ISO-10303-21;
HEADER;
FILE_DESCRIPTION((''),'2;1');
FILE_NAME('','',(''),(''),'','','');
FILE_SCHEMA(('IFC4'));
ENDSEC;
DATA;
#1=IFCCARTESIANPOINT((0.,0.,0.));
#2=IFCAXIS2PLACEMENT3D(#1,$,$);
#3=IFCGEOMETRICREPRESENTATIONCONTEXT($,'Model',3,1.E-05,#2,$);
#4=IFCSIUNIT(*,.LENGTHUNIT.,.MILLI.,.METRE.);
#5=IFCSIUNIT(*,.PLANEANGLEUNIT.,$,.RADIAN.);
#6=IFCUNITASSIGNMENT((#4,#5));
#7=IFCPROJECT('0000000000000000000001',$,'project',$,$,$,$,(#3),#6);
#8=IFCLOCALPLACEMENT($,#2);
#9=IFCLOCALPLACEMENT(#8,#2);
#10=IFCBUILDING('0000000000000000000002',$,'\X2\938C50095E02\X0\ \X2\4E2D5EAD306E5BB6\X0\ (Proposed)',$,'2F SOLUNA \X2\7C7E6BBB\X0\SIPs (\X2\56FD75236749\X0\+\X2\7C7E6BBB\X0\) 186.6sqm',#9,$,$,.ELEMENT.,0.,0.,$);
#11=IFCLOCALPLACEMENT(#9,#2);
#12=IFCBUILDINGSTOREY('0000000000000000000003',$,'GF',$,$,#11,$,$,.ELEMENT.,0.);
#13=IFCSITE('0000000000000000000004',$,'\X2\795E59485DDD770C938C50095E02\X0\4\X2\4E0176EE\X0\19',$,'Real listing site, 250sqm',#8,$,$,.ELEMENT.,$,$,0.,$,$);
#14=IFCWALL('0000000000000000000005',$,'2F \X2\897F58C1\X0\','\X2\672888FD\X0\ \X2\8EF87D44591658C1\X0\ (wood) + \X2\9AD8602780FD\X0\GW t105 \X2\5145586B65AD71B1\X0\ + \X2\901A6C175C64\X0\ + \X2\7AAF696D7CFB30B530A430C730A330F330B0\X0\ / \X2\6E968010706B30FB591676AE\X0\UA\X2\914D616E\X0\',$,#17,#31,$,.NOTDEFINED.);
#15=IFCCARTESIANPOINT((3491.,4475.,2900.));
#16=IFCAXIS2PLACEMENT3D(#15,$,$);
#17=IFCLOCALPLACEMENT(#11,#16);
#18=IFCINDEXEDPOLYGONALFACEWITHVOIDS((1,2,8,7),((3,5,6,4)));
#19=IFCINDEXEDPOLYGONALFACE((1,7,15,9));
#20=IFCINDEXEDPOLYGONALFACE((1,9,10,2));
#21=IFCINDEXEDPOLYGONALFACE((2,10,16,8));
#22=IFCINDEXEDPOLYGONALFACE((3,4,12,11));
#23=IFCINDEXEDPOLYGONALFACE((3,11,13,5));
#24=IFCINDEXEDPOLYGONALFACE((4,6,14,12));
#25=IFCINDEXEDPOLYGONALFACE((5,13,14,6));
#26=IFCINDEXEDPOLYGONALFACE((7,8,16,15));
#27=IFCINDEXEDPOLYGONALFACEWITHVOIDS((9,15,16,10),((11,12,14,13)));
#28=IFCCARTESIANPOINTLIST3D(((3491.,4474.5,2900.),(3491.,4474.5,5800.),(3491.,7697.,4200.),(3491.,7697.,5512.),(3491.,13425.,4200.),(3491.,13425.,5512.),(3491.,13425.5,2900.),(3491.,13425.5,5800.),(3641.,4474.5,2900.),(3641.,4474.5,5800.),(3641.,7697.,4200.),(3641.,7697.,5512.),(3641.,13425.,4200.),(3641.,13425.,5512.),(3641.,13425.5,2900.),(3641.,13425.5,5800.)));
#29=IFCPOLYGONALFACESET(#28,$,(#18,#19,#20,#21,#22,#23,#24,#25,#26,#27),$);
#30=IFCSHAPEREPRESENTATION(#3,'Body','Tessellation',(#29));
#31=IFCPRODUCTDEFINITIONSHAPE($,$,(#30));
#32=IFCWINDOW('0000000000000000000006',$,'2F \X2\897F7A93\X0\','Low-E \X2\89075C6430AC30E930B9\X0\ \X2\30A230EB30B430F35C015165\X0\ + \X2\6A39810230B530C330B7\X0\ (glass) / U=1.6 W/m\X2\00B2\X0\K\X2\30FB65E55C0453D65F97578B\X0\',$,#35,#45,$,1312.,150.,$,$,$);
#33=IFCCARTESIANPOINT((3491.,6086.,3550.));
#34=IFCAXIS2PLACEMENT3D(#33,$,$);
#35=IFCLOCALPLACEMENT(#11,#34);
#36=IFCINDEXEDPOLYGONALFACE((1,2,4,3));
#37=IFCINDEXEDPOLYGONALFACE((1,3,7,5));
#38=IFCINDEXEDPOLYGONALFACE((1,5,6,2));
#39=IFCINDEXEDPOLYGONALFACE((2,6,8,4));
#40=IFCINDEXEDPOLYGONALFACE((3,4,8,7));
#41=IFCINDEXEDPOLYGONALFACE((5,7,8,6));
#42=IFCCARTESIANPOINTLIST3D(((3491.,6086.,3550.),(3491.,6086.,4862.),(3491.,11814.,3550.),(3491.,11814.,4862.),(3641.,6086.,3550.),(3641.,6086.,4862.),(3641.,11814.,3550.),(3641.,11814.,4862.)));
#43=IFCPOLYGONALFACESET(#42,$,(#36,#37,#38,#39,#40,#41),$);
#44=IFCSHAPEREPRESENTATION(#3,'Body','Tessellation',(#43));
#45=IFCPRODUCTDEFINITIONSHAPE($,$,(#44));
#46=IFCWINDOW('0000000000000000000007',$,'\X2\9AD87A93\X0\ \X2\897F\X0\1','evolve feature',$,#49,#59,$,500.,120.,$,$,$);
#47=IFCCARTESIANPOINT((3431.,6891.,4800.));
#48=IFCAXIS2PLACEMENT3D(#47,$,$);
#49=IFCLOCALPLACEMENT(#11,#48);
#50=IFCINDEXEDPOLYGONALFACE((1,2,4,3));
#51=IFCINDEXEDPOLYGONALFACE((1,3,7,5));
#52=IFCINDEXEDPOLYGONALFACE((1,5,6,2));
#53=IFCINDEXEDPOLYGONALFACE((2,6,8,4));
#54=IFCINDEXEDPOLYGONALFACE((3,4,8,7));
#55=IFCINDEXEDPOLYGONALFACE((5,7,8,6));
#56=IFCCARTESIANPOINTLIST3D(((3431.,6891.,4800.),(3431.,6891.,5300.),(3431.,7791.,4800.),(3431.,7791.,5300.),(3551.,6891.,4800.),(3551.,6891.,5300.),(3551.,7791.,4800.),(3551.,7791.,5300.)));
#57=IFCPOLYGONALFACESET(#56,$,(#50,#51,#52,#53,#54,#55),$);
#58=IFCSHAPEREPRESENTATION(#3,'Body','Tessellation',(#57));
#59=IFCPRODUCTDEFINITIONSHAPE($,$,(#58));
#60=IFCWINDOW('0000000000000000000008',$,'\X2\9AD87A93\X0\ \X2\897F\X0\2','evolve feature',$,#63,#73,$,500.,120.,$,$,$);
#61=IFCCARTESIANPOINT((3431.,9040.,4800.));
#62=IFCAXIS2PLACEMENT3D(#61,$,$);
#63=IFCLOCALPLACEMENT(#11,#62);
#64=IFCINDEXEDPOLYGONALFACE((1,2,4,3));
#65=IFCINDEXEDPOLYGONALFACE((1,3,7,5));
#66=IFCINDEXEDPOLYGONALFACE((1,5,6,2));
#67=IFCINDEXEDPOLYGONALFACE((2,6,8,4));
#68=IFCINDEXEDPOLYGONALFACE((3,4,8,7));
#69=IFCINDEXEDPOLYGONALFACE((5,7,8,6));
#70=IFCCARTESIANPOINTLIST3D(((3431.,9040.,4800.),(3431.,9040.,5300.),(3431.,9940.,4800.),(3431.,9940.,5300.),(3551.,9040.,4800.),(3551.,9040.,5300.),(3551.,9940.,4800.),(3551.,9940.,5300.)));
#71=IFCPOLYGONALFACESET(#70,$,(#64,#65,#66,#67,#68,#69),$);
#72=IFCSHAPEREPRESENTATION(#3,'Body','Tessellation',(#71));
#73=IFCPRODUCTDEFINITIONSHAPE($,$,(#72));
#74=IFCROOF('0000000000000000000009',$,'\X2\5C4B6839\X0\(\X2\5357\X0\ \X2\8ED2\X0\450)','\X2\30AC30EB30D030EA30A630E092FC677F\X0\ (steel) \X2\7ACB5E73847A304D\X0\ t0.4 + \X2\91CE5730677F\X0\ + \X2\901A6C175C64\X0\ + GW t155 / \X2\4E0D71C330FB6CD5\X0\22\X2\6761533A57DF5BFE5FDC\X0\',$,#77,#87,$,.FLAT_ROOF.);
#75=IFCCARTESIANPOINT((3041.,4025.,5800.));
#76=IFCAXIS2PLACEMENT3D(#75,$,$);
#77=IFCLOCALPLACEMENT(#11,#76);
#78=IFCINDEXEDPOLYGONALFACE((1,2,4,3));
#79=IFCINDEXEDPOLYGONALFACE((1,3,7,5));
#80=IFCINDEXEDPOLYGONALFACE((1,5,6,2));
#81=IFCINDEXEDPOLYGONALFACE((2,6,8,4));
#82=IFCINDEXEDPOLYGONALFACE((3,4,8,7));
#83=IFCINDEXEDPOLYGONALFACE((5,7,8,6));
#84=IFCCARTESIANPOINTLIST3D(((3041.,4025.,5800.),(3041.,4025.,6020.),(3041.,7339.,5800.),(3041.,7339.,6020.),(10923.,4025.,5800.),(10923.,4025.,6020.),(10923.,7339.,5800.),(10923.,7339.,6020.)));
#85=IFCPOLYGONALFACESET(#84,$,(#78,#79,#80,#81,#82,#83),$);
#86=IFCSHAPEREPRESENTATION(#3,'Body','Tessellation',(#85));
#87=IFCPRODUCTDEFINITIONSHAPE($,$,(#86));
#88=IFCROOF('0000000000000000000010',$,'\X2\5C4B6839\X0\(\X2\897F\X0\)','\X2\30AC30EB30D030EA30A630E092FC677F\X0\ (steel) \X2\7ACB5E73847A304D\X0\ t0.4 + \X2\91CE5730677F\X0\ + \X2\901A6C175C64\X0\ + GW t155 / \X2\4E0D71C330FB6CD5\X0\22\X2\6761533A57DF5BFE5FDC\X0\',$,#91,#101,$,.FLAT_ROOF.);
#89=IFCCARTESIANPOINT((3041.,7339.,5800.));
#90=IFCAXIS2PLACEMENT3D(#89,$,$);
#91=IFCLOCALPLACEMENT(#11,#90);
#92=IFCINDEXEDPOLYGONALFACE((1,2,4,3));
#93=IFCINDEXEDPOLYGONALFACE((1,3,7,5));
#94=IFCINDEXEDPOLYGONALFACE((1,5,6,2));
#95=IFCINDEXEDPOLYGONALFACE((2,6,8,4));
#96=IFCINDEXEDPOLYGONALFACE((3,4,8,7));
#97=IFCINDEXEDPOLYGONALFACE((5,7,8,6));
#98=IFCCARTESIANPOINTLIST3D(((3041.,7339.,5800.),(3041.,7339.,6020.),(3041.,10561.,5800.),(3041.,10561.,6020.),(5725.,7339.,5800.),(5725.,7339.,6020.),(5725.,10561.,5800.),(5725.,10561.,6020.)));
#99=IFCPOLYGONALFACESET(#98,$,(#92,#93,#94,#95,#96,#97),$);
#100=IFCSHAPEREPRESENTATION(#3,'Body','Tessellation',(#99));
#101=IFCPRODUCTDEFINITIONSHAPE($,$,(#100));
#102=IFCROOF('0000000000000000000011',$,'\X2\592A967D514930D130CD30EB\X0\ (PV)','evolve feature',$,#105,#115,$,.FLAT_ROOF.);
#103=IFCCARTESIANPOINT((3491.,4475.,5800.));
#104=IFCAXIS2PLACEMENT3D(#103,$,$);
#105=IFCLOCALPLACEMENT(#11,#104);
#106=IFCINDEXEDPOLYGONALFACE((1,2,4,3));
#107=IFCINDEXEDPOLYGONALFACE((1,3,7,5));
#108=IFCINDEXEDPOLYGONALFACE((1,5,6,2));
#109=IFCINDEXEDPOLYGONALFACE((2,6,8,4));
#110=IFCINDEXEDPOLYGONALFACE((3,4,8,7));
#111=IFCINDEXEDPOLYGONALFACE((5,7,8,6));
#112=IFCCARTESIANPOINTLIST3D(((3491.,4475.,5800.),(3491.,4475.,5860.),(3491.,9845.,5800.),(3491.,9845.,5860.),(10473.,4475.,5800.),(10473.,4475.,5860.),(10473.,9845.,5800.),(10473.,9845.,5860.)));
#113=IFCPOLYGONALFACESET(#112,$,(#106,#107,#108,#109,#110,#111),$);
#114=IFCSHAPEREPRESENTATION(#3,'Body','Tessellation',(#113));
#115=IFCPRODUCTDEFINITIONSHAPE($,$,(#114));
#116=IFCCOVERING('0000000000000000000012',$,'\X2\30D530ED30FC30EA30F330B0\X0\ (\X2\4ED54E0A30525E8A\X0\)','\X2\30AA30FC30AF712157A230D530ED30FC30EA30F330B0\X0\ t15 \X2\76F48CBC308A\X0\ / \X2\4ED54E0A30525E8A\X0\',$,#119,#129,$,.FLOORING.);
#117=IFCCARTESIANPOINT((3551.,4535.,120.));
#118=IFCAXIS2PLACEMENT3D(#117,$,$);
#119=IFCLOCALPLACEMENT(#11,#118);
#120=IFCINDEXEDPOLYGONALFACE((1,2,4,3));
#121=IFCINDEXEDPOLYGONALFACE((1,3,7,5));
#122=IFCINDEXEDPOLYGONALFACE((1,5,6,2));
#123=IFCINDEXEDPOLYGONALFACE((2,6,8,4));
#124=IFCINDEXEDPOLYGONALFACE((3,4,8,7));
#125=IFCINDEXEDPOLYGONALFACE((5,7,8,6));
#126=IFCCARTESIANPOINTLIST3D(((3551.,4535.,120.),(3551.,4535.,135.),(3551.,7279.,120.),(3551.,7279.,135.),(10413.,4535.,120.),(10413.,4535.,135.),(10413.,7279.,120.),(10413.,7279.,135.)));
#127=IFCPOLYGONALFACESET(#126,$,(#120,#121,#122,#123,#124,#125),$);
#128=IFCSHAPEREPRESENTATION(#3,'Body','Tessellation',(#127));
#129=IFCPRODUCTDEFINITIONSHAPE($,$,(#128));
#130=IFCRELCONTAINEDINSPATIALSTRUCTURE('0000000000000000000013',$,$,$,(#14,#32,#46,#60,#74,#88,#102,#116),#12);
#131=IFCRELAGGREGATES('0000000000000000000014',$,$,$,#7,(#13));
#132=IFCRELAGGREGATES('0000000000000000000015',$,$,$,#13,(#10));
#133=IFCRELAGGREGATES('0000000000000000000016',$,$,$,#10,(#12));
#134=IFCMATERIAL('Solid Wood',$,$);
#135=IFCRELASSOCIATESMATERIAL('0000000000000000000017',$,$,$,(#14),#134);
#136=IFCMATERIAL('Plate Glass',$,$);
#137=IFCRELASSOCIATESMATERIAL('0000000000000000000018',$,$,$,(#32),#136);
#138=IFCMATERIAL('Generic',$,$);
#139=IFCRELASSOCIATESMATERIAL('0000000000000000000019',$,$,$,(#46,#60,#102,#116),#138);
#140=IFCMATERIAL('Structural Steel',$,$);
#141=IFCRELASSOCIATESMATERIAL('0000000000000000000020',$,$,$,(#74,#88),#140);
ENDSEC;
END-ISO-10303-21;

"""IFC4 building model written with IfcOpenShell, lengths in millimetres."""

from ifc_helpers import new_model, si_unit, frame, frame_2d, origin, place, context, project, spatial, rectangle, extrude, material, element, fill, save


model = new_model("IFC4")

# Units and contexts
model_context = context("Model", 3, precision=1e-05, world=origin())
ifc_project = project(units=[si_unit("LENGTHUNIT", "METRE", prefix="MILLI"), si_unit("PLANEANGLEUNIT", "RADIAN")], contexts=[model_context])

# Site, building, storey
site_placement = place(None, origin())
site = spatial("IfcSite", under=ifc_project, at=site_placement, Name="神奈川県鎌倉市4丁目19", ObjectType="Real listing site, 250sqm", CompositionType="ELEMENT", RefElevation=0.0)
building_placement = place(site_placement, origin())
building = spatial("IfcBuilding", under=site, at=building_placement, Name="鎌倉市 中庭の家 (Proposed)", ObjectType="2F SOLUNA 籾殻SIPs (国産杉+籾殻) 186.6sqm", CompositionType="ELEMENT", ElevationOfRefHeight=0.0, ElevationOfTerrain=0.0)
storey_placement = place(building_placement, origin())
storey = spatial("IfcBuildingStorey", under=building, at=storey_placement, Name="GF", CompositionType="ELEMENT", Elevation=0.0)

# Shared definitions
ifc_material_1 = material(Name="Solid Wood")
ifc_material_2 = material(Name="Generic")

# Shared definitions
ifc_material_3 = material(Name="Plate Glass")

# Wall, openings, windows
wall_1_placement = place(storey_placement, frame((3491.0, 4475.0, 2900.0)))
wall_1 = element("IfcWall", 1, at=wall_1_placement, inside=storey, material=ifc_material_1, Name="2F 西壁", Description="木製 軸組外壁 (wood) + 高性能GW t105 充填断熱 + 通気層 + 窯業系サイディング / 準耐火・外皮UA配慮", PredefinedType="NOTDEFINED", context=model_context, shape_type="SweptSolid", body=[
    extrude(rectangle(XDim=150.0, YDim=8951.0, at=frame_2d((75.0, 4475.0))), frame((3491.0, 4475.0, 2900.0)), (0.0, 0.0, 1.0), 2900.0),
])
opening_1_placement = place(storey_placement, frame((3491.0, 6086.0, 3550.0)))
opening_1 = element("IfcOpeningElement", 2, at=opening_1_placement, cuts=wall_1, PredefinedType="NOTDEFINED", context=model_context, shape_type="SweptSolid", body=[
    extrude(rectangle(XDim=150.0, YDim=5728.0, at=frame_2d((75.0, 2864.0))), frame((3491.0, 6086.0, 3550.0)), (0.0, 0.0, 1.0), 1312.0),
])
opening_2_placement = place(storey_placement, frame((3431.0, 6891.0, 4800.0)))
opening_2 = element("IfcOpeningElement", 3, at=opening_2_placement, cuts=wall_1, PredefinedType="NOTDEFINED", context=model_context, shape_type="SweptSolid", body=[
    extrude(rectangle(XDim=120.0, YDim=900.0, at=frame_2d((60.0, 450.0))), frame((3431.0, 6891.0, 4800.0)), (0.0, 0.0, 1.0), 500.0),
])
opening_3_placement = place(storey_placement, frame((3431.0, 9040.0, 4800.0)))
opening_3 = element("IfcOpeningElement", 4, at=opening_3_placement, cuts=wall_1, PredefinedType="NOTDEFINED", context=model_context, shape_type="SweptSolid", body=[
    extrude(rectangle(XDim=120.0, YDim=900.0, at=frame_2d((60.0, 450.0))), frame((3431.0, 9040.0, 4800.0)), (0.0, 0.0, 1.0), 500.0),
])
window_1_placement = place(storey_placement, frame((3491.0, 6086.0, 3550.0)))
window_1 = element("IfcWindow", 5, at=window_1_placement, inside=storey, material=ifc_material_3, Name="2F 西窓", Description="Low-E 複層ガラス アルゴン封入 + 樹脂サッシ (glass) / U=1.6 W/m²K・日射取得型", OverallHeight=1312.0, OverallWidth=150.0, context=model_context, shape_type="SweptSolid", body=[
    extrude(rectangle(XDim=150.0, YDim=5728.0, at=frame_2d((75.0, 2864.0))), frame((3491.0, 6086.0, 3550.0)), (0.0, 0.0, 1.0), 1312.0),
])
fill(opening_1, window_1)
window_2_placement = place(storey_placement, frame((3431.0, 6891.0, 4800.0)))
window_2 = element("IfcWindow", 6, at=window_2_placement, inside=storey, material=ifc_material_2, Name="高窓 西1", Description="evolve feature", OverallHeight=500.0, OverallWidth=120.0, context=model_context, shape_type="SweptSolid", body=[
    extrude(rectangle(XDim=120.0, YDim=900.0, at=frame_2d((60.0, 450.0))), frame((3431.0, 6891.0, 4800.0)), (0.0, 0.0, 1.0), 500.0),
])
fill(opening_2, window_2)
window_3_placement = place(storey_placement, frame((3431.0, 9040.0, 4800.0)))
window_3 = element("IfcWindow", 7, at=window_3_placement, inside=storey, material=ifc_material_2, Name="高窓 西2", Description="evolve feature", OverallHeight=500.0, OverallWidth=120.0, context=model_context, shape_type="SweptSolid", body=[
    extrude(rectangle(XDim=120.0, YDim=900.0, at=frame_2d((60.0, 450.0))), frame((3431.0, 9040.0, 4800.0)), (0.0, 0.0, 1.0), 500.0),
])
fill(opening_3, window_3)

# Roofs
ifc_material_4 = material(Name="Structural Steel")
roof_1_placement = place(storey_placement, frame((3041.0, 4025.0, 5800.0)))
element("IfcRoof", 8, at=roof_1_placement, inside=storey, material=ifc_material_4, Name="屋根(南 軒450)", Description="ガルバリウム鋼板 (steel) 立平葺き t0.4 + 野地板 + 通気層 + GW t155 / 不燃・法22条区域対応", PredefinedType="FLAT_ROOF", context=model_context, shape_type="SweptSolid", body=[
    extrude(rectangle(XDim=7882.0, YDim=3314.0, at=frame_2d((3941.0, 1657.0))), frame((3041.0, 4025.0, 5800.0)), (0.0, 0.0, 1.0), 220.0),
])
roof_2_placement = place(storey_placement, frame((3041.0, 7339.0, 5800.0)))
element("IfcRoof", 9, at=roof_2_placement, inside=storey, material=ifc_material_4, Name="屋根(西)", Description="ガルバリウム鋼板 (steel) 立平葺き t0.4 + 野地板 + 通気層 + GW t155 / 不燃・法22条区域対応", PredefinedType="FLAT_ROOF", context=model_context, shape_type="SweptSolid", body=[
    extrude(rectangle(XDim=2684.0, YDim=3222.0, at=frame_2d((1342.0, 1611.0))), frame((3041.0, 7339.0, 5800.0)), (0.0, 0.0, 1.0), 220.0),
])
roof_3_placement = place(storey_placement, frame((3491.0, 4475.0, 5800.0)))
element("IfcRoof", 10, at=roof_3_placement, inside=storey, material=ifc_material_2, Name="太陽光パネル (PV)", Description="evolve feature", PredefinedType="FLAT_ROOF", context=model_context, shape_type="SweptSolid", body=[
    extrude(rectangle(XDim=6982.0, YDim=5370.0, at=frame_2d((3491.0, 2685.0))), frame((3491.0, 4475.0, 5800.0)), (0.0, 0.0, 1.0), 60.0),
])

# Covering
covering_placement = place(storey_placement, frame((3551.0, 4535.0, 120.0)))
element("IfcCovering", 11, at=covering_placement, inside=storey, material=ifc_material_2, Name="フローリング (仕上げ床)", Description="オーク無垢フローリング t15 直貼り / 仕上げ床", PredefinedType="FLOORING", context=model_context, shape_type="SweptSolid", body=[
    extrude(rectangle(XDim=6862.0, YDim=2744.0, at=frame_2d((3431.0, 1372.0))), frame((3551.0, 4535.0, 120.0)), (0.0, 0.0, 1.0), 15.0),
])

save(model, "model.ifc")
